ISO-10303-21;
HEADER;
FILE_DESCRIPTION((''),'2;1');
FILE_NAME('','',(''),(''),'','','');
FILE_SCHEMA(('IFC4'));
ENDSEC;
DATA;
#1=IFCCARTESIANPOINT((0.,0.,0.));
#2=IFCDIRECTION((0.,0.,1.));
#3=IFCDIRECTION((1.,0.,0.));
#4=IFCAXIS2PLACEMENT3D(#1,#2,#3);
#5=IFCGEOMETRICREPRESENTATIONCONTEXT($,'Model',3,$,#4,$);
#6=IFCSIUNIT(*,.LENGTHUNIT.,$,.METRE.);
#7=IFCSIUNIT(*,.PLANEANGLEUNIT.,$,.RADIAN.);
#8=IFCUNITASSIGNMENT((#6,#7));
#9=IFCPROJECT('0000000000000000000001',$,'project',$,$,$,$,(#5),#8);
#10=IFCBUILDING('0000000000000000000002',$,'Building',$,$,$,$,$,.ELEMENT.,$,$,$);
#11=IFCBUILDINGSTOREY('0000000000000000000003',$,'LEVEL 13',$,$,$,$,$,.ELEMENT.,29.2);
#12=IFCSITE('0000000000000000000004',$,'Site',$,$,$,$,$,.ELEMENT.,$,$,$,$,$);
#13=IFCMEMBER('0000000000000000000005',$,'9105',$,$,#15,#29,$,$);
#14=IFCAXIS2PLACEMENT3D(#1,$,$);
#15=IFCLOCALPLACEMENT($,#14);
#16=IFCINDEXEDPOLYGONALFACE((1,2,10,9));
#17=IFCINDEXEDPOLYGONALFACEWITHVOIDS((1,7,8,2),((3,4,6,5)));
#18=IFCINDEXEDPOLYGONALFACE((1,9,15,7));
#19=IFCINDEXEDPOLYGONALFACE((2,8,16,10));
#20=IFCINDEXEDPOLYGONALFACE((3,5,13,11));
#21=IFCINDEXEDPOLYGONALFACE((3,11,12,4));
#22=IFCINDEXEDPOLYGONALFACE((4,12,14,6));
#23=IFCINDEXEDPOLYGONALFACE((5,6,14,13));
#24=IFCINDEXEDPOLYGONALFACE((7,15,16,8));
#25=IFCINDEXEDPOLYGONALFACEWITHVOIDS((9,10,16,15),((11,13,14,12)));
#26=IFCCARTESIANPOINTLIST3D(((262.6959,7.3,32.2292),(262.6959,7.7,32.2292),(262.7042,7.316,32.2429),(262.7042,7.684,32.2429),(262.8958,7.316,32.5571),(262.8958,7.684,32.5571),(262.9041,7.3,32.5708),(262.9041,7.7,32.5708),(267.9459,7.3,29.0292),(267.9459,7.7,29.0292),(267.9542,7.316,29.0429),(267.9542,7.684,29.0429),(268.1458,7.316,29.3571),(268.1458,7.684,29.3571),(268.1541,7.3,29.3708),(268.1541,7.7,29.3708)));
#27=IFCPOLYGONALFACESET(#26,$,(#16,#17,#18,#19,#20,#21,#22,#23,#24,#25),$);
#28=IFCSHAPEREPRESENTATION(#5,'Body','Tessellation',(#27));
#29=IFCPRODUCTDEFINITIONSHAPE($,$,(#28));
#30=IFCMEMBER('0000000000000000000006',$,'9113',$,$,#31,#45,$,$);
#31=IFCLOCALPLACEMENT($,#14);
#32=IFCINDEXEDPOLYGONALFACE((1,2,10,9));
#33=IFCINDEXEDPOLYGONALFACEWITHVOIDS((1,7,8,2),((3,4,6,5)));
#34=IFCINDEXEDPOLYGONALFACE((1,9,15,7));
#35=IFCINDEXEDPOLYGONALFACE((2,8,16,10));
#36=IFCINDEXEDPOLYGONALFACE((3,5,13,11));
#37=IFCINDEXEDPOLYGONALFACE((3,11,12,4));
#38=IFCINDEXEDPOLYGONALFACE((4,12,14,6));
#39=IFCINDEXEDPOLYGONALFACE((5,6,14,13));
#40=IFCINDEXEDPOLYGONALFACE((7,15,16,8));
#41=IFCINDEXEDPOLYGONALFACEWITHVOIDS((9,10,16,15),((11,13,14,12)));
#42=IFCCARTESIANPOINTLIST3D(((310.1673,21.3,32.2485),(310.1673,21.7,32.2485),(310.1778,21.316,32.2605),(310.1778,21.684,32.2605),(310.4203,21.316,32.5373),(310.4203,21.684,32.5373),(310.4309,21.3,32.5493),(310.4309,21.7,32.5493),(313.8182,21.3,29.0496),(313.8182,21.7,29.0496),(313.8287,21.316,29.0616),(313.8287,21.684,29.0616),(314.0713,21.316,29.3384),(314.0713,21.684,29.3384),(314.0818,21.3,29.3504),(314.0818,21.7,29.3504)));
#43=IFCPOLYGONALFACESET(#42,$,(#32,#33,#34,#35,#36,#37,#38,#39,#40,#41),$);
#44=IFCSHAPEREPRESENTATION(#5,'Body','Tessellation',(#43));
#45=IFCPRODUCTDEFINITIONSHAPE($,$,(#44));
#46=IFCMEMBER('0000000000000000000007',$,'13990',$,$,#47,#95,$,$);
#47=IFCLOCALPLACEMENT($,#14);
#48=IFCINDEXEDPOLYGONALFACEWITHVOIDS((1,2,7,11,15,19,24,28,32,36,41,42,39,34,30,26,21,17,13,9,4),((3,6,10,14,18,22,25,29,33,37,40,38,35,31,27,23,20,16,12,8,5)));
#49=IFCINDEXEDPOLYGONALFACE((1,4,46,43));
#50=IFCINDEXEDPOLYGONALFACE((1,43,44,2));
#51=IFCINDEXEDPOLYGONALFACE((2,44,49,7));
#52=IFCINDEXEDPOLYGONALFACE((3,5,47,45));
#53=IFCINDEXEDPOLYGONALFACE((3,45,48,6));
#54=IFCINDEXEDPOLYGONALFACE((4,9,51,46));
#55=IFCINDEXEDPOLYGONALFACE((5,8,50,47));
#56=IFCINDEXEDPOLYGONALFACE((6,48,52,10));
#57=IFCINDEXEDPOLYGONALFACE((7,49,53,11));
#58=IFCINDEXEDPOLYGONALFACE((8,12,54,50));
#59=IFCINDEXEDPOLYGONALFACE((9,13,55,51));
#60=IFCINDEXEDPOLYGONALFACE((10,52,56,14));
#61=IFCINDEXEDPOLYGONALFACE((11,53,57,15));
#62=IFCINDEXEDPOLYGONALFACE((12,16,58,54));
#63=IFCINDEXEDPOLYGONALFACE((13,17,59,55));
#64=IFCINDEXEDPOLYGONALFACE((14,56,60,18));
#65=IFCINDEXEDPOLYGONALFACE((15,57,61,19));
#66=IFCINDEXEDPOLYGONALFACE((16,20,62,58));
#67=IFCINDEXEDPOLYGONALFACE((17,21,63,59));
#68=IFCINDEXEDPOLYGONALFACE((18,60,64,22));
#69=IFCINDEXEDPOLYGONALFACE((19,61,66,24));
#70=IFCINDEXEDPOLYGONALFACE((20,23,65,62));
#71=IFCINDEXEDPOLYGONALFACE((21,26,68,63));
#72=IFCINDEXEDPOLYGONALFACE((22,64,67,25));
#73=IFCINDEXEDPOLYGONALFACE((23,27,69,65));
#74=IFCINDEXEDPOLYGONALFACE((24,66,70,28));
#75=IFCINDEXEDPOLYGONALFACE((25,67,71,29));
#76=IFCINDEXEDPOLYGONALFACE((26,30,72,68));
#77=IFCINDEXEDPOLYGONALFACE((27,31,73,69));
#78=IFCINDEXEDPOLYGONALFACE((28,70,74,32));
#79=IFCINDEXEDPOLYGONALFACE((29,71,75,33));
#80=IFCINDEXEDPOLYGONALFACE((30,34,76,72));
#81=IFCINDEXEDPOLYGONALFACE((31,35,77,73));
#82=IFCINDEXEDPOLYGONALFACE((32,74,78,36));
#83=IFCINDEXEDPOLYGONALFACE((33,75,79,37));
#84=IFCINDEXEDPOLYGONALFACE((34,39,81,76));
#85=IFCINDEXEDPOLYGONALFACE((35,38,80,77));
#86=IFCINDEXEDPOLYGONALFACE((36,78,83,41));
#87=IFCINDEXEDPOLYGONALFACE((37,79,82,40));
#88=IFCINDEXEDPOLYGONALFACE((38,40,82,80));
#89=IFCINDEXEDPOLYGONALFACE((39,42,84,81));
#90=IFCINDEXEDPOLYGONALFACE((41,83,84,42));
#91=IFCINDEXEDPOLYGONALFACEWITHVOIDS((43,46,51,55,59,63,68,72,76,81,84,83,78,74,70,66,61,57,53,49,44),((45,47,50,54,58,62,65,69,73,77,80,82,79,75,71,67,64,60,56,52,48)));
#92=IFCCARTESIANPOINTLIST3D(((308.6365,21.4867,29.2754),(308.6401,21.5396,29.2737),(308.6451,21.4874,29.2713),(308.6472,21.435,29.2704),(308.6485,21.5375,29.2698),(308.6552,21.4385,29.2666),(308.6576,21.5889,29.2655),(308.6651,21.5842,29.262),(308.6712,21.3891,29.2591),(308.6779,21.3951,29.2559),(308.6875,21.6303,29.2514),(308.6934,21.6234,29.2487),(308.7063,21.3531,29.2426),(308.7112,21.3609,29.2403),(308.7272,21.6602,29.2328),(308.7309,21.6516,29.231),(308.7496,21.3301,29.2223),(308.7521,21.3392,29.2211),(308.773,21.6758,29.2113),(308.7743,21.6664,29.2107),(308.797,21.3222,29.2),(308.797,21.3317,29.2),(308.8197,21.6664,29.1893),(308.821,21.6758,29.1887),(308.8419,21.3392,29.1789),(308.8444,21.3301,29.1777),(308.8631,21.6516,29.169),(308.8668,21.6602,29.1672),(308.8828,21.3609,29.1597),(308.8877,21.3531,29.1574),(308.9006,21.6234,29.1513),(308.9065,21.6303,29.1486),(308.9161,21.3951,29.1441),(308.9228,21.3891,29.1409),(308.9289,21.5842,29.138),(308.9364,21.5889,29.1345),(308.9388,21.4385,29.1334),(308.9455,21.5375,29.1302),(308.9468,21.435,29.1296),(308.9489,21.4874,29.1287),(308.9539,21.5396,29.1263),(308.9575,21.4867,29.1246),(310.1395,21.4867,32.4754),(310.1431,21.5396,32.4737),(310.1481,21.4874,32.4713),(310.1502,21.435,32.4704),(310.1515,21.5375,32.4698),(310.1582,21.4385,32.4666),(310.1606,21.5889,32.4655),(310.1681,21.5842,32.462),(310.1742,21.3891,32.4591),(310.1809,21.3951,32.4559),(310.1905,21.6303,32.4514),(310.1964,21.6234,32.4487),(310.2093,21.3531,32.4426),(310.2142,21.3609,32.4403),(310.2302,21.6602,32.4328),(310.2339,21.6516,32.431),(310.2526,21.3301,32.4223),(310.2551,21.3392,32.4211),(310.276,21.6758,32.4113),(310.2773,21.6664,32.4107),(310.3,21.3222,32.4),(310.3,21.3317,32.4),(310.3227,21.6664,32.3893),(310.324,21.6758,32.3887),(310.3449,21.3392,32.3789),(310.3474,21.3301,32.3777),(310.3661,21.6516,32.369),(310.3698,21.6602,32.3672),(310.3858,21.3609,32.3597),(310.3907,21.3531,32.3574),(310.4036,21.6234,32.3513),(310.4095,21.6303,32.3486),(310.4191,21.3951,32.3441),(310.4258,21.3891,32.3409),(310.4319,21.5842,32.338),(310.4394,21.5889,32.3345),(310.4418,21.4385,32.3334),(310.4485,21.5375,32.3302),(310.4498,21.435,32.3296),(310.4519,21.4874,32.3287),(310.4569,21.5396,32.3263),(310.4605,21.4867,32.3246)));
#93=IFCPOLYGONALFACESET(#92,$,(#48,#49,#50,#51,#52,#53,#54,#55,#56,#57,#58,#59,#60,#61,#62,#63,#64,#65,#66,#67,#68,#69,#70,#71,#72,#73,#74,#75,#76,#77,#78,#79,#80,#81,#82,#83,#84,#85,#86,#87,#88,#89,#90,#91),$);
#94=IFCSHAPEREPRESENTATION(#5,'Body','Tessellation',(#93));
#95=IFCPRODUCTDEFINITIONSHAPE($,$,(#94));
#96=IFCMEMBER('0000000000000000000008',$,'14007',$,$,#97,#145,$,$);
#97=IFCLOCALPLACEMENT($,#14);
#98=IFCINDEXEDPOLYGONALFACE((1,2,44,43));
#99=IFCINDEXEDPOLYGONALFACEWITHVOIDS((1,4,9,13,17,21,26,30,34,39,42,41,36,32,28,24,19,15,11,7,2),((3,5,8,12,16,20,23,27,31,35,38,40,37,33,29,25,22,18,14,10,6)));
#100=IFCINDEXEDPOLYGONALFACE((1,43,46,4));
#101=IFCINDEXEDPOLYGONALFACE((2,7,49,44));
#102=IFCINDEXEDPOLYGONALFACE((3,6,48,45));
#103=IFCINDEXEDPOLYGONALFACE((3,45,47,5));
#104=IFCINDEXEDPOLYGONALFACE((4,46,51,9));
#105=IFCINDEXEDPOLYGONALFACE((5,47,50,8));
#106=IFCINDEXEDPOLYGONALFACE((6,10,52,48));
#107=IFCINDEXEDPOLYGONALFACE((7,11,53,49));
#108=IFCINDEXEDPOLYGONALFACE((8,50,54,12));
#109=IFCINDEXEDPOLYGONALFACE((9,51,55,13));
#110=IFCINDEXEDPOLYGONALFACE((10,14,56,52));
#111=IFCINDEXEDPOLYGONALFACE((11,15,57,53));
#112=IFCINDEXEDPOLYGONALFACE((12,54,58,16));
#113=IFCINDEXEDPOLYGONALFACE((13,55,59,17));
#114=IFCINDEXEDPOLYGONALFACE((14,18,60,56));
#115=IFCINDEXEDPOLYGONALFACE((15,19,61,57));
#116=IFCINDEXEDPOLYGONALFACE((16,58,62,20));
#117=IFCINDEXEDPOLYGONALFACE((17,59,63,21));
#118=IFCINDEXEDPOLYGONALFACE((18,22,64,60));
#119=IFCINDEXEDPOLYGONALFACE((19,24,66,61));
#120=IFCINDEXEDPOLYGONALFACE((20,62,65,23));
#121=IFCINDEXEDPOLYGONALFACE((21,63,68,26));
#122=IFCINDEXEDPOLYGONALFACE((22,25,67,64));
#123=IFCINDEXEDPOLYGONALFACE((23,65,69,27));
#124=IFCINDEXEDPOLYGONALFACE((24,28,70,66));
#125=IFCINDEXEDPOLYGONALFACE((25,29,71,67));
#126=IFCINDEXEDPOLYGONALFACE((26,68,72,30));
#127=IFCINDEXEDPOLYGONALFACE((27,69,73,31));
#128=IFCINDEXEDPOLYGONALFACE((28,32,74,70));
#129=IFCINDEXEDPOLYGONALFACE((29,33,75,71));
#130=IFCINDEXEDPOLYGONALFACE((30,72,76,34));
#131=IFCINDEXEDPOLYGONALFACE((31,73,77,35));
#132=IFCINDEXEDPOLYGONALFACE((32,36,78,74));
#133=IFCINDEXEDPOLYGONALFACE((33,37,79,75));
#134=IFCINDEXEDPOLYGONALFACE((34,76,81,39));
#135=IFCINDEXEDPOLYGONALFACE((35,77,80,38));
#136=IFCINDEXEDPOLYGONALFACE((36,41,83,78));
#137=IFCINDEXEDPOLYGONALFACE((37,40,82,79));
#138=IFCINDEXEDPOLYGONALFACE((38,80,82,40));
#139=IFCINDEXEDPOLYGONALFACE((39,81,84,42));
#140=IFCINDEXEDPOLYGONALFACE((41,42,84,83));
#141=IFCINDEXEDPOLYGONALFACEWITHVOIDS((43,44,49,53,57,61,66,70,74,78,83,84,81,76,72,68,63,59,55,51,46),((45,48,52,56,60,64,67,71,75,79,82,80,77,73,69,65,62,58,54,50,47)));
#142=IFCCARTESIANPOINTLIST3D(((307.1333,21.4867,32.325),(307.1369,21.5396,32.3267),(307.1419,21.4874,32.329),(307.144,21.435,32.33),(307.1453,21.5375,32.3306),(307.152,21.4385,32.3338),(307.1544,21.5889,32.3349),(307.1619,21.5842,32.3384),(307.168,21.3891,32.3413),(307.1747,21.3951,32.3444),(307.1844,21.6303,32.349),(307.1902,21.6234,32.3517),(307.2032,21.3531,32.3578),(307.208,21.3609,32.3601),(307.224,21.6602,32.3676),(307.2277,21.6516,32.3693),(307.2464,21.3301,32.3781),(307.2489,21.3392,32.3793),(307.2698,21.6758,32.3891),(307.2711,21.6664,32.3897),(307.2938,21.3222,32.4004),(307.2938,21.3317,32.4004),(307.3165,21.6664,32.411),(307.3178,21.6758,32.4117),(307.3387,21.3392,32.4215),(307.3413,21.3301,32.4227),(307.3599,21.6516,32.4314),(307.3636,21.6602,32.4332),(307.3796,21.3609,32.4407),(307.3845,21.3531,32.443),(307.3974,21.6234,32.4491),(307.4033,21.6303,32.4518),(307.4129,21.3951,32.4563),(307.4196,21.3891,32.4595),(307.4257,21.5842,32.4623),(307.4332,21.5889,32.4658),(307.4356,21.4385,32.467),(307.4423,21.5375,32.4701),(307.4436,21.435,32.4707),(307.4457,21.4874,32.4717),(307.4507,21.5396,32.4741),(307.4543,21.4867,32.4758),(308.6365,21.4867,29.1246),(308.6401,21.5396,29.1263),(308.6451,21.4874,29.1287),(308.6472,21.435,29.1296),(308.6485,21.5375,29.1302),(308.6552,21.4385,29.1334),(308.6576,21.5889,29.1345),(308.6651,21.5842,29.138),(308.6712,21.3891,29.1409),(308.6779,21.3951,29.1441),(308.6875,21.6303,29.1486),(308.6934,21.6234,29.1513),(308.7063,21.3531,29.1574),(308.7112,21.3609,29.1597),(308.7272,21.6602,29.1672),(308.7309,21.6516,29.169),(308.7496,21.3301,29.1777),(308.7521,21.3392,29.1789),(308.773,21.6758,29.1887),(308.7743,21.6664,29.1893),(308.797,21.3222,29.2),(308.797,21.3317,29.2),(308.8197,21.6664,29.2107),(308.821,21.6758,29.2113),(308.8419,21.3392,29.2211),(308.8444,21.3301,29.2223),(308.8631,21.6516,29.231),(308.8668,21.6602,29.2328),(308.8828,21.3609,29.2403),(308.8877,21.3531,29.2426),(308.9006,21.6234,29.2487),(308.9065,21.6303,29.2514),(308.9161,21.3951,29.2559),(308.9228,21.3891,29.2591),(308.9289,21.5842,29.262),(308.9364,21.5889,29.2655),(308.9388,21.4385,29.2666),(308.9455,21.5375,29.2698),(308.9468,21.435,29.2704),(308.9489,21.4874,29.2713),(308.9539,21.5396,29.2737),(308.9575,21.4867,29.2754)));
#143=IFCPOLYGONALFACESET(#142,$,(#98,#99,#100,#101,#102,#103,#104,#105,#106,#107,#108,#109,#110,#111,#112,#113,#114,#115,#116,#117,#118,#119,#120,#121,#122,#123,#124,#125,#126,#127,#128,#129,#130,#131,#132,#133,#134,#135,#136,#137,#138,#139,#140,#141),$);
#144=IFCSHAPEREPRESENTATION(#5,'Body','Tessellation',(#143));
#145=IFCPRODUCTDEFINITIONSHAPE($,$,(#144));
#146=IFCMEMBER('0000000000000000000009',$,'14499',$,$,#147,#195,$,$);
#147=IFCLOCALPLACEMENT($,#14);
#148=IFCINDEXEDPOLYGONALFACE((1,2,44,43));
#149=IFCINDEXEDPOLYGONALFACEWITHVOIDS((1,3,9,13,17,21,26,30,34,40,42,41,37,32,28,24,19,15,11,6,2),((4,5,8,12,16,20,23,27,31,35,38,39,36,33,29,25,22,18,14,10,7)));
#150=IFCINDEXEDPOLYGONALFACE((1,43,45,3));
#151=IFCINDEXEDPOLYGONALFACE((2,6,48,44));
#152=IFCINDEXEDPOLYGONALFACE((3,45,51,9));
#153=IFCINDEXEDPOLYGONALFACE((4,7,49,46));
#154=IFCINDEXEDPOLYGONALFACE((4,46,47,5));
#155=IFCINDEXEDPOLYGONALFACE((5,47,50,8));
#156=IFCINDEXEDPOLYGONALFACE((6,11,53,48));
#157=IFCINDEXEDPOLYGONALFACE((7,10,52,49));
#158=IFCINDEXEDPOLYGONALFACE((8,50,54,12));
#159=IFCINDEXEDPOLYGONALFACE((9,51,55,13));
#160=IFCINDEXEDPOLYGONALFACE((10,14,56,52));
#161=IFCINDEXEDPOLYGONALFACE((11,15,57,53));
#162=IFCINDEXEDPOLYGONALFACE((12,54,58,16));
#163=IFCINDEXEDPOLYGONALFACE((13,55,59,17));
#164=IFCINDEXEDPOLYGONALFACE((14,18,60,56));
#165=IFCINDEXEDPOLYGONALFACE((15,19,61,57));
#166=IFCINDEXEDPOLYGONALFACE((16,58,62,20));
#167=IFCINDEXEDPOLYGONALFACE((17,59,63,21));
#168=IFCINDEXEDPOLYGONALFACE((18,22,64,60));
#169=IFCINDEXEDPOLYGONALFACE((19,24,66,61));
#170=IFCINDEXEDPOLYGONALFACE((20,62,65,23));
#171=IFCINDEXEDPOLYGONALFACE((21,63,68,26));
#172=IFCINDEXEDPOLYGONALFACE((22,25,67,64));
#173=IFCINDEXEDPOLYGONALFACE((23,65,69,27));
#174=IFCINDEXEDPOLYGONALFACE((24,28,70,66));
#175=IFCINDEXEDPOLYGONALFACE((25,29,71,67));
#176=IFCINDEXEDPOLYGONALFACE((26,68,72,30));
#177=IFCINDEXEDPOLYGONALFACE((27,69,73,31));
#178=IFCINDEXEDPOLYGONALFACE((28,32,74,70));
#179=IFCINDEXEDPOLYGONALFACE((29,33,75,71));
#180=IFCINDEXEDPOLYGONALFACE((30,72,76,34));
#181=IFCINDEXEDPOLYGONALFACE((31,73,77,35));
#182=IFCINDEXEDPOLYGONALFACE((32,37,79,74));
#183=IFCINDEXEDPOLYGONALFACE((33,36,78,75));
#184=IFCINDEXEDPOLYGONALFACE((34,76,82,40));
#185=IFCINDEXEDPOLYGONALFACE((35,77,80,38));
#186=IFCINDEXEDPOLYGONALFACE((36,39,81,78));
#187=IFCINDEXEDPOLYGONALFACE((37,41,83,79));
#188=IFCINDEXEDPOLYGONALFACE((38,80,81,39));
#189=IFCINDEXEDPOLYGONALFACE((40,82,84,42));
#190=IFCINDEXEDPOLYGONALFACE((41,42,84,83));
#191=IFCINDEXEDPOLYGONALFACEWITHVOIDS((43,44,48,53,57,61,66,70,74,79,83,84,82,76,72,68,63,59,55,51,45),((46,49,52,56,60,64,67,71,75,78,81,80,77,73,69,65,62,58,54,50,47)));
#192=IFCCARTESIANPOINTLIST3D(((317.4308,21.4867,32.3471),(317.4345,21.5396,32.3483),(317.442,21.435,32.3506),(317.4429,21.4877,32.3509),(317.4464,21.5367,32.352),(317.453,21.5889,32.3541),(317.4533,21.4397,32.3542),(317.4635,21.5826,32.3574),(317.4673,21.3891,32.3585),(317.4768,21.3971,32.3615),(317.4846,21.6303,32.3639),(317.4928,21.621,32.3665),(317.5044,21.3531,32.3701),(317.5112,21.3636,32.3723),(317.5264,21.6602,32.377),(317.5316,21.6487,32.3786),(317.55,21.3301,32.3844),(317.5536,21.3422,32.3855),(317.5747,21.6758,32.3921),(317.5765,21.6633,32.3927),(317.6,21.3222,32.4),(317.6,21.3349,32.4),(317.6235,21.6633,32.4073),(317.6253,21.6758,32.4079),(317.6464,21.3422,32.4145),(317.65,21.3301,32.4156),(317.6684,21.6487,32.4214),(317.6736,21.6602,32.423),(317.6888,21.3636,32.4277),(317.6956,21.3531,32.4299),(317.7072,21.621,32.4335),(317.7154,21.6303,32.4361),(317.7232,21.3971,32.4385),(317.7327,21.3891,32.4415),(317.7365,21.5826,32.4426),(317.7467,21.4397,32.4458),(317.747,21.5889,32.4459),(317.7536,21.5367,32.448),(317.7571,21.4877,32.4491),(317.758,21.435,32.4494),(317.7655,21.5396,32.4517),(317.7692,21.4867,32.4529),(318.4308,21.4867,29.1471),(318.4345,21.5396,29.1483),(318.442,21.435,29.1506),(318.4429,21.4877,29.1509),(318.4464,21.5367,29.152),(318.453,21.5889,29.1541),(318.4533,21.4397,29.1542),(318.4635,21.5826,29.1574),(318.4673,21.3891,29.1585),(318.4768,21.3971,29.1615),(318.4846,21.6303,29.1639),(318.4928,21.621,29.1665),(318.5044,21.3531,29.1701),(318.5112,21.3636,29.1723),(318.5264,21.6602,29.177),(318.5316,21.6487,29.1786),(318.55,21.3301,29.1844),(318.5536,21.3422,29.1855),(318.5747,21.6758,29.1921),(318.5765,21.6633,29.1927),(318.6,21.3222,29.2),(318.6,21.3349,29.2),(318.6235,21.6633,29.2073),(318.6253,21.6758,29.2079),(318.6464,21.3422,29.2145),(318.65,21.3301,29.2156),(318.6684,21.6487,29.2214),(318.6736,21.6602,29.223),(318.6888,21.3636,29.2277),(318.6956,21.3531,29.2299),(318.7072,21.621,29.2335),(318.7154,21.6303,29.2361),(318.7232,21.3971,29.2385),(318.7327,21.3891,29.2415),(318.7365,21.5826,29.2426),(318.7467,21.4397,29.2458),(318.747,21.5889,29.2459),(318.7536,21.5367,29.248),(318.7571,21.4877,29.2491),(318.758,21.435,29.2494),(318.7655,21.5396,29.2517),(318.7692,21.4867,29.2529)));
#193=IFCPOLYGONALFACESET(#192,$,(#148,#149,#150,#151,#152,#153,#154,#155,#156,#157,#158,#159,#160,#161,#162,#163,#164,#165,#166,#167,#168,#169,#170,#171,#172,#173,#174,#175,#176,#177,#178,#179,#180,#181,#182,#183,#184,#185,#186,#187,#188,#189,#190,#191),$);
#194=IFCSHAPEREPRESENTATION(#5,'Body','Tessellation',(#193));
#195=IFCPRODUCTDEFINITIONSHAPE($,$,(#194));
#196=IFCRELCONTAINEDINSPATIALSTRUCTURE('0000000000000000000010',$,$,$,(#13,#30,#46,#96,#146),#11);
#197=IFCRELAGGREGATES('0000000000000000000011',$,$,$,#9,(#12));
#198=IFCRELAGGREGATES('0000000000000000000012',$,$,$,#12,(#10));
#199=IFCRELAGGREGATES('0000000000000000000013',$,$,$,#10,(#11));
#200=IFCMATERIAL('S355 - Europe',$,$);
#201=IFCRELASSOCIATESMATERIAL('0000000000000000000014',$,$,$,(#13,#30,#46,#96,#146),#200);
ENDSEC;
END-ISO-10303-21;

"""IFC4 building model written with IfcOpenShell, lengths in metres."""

from ifc_helpers import new_model, si_unit, frame, origin_with_axes, origin_2d_with_axis, place, context, project, spatial, hollow_rectangle, hollow_circle, extrude, material, material_profile, profile_set, profile_usage, element, save


model = new_model("IFC4")

# Units and contexts
model_context = context("Model", 3, world=origin_with_axes())
ifc_project = project(units=[si_unit("LENGTHUNIT", "METRE"), si_unit("PLANEANGLEUNIT", "RADIAN")], contexts=[model_context])

# Site, building, storey
site = spatial("IfcSite", under=ifc_project, Name="Site", CompositionType="ELEMENT")
building = spatial("IfcBuilding", under=site, Name="Building", CompositionType="ELEMENT")
storey = spatial("IfcBuildingStorey", under=building, Name="LEVEL 13", CompositionType="ELEMENT", Elevation=29.2)

# Members
ifc_material = material(Name="S355 - Europe")
ifc_material_profile_1 = material_profile(ifc_material, hollow_rectangle(XDim=0.4, YDim=0.4, WallThickness=0.016, at=origin_2d_with_axis()))
ifc_profile_set_1 = profile_set([ifc_material_profile_1])
ifc_profile_usage_1 = profile_usage(ifc_profile_set_1, cardinal=10)
member_1_placement = place(None, frame((268.05, 7.5, 29.2), z_axis=(-0.853884, 0.0, 0.520463), x_axis=(0.0, -1.0, 0.0)))
element("IfcMember", 1, at=member_1_placement, inside=storey, material=ifc_profile_usage_1, Name="9105", context=model_context, shape_type="SweptSolid", body=[
    extrude(hollow_rectangle(XDim=0.4, YDim=0.4, WallThickness=0.016, at=origin_2d_with_axis()), origin_with_axes(), (0.0, 0.0, 1.0), 6.1484),
])
ifc_material_profile_2 = material_profile(ifc_material, hollow_rectangle(XDim=0.4, YDim=0.4, WallThickness=0.016, at=origin_2d_with_axis()))
ifc_profile_set_2 = profile_set([ifc_material_profile_2])
ifc_profile_usage_2 = profile_usage(ifc_profile_set_2, cardinal=10)
member_2_placement = place(None, frame((313.95, 21.5, 29.2), z_axis=(-0.752133, 0.0, 0.659012), x_axis=(0.0, -1.0, 0.0)))
element("IfcMember", 2, at=member_2_placement, inside=storey, material=ifc_profile_usage_2, Name="9113", context=model_context, shape_type="SweptSolid", body=[
    extrude(hollow_rectangle(XDim=0.4, YDim=0.4, WallThickness=0.016, at=origin_2d_with_axis()), origin_with_axes(), (0.0, 0.0, 1.0), 4.8541),
])
ifc_material_profile_3 = material_profile(ifc_material, hollow_circle(Radius=0.1778, WallThickness=0.0095, at=origin_2d_with_axis()))
ifc_profile_set_3 = profile_set([ifc_material_profile_3])
ifc_profile_usage_3 = profile_usage(ifc_profile_set_3, cardinal=10)
member_3_placement = place(None, frame((310.3, 21.5, 32.4), z_axis=(-0.425129, 0.0, -0.905133), x_axis=(0.0, -1.0, 0.0)))
element("IfcMember", 3, at=member_3_placement, inside=storey, material=ifc_profile_usage_3, Name="13990", context=model_context, shape_type="SweptSolid", body=[
    extrude(hollow_circle(Radius=0.1778, WallThickness=0.0095, at=origin_2d_with_axis()), origin_with_axes(), (0.0, 0.0, 1.0), 3.5354),
])
ifc_material_profile_4 = material_profile(ifc_material, hollow_circle(Radius=0.1778, WallThickness=0.0095, at=origin_2d_with_axis()))
ifc_profile_set_4 = profile_set([ifc_material_profile_4])
ifc_profile_usage_4 = profile_usage(ifc_profile_set_4, cardinal=10)
member_4_placement = place(None, frame((308.797, 21.5, 29.2), z_axis=(-0.425129, 0.0, 0.905133), x_axis=(0.0, -1.0, 0.0)))
element("IfcMember", 4, at=member_4_placement, inside=storey, material=ifc_profile_usage_4, Name="14007", context=model_context, shape_type="SweptSolid", body=[
    extrude(hollow_circle(Radius=0.1778, WallThickness=0.0095, at=origin_2d_with_axis()), origin_with_axes(), (0.0, 0.0, 1.0), 3.5358),
])
ifc_material_profile_5 = material_profile(ifc_material, hollow_circle(Radius=0.1778, WallThickness=0.0127, at=origin_2d_with_axis()))
ifc_profile_set_5 = profile_set([ifc_material_profile_5])
ifc_profile_usage_5 = profile_usage(ifc_profile_set_5, cardinal=10)
member_5_placement = place(None, frame((318.6, 21.5, 29.2), z_axis=(-0.298275, 0.0, 0.95448), x_axis=(0.0, -1.0, 0.0)))
element("IfcMember", 5, at=member_5_placement, inside=storey, material=ifc_profile_usage_5, Name="14499", context=model_context, shape_type="SweptSolid", body=[
    extrude(hollow_circle(Radius=0.1778, WallThickness=0.0127, at=origin_2d_with_axis()), origin_with_axes(), (0.0, 0.0, 1.0), 3.3526),
])

save(model, "model.ifc")
